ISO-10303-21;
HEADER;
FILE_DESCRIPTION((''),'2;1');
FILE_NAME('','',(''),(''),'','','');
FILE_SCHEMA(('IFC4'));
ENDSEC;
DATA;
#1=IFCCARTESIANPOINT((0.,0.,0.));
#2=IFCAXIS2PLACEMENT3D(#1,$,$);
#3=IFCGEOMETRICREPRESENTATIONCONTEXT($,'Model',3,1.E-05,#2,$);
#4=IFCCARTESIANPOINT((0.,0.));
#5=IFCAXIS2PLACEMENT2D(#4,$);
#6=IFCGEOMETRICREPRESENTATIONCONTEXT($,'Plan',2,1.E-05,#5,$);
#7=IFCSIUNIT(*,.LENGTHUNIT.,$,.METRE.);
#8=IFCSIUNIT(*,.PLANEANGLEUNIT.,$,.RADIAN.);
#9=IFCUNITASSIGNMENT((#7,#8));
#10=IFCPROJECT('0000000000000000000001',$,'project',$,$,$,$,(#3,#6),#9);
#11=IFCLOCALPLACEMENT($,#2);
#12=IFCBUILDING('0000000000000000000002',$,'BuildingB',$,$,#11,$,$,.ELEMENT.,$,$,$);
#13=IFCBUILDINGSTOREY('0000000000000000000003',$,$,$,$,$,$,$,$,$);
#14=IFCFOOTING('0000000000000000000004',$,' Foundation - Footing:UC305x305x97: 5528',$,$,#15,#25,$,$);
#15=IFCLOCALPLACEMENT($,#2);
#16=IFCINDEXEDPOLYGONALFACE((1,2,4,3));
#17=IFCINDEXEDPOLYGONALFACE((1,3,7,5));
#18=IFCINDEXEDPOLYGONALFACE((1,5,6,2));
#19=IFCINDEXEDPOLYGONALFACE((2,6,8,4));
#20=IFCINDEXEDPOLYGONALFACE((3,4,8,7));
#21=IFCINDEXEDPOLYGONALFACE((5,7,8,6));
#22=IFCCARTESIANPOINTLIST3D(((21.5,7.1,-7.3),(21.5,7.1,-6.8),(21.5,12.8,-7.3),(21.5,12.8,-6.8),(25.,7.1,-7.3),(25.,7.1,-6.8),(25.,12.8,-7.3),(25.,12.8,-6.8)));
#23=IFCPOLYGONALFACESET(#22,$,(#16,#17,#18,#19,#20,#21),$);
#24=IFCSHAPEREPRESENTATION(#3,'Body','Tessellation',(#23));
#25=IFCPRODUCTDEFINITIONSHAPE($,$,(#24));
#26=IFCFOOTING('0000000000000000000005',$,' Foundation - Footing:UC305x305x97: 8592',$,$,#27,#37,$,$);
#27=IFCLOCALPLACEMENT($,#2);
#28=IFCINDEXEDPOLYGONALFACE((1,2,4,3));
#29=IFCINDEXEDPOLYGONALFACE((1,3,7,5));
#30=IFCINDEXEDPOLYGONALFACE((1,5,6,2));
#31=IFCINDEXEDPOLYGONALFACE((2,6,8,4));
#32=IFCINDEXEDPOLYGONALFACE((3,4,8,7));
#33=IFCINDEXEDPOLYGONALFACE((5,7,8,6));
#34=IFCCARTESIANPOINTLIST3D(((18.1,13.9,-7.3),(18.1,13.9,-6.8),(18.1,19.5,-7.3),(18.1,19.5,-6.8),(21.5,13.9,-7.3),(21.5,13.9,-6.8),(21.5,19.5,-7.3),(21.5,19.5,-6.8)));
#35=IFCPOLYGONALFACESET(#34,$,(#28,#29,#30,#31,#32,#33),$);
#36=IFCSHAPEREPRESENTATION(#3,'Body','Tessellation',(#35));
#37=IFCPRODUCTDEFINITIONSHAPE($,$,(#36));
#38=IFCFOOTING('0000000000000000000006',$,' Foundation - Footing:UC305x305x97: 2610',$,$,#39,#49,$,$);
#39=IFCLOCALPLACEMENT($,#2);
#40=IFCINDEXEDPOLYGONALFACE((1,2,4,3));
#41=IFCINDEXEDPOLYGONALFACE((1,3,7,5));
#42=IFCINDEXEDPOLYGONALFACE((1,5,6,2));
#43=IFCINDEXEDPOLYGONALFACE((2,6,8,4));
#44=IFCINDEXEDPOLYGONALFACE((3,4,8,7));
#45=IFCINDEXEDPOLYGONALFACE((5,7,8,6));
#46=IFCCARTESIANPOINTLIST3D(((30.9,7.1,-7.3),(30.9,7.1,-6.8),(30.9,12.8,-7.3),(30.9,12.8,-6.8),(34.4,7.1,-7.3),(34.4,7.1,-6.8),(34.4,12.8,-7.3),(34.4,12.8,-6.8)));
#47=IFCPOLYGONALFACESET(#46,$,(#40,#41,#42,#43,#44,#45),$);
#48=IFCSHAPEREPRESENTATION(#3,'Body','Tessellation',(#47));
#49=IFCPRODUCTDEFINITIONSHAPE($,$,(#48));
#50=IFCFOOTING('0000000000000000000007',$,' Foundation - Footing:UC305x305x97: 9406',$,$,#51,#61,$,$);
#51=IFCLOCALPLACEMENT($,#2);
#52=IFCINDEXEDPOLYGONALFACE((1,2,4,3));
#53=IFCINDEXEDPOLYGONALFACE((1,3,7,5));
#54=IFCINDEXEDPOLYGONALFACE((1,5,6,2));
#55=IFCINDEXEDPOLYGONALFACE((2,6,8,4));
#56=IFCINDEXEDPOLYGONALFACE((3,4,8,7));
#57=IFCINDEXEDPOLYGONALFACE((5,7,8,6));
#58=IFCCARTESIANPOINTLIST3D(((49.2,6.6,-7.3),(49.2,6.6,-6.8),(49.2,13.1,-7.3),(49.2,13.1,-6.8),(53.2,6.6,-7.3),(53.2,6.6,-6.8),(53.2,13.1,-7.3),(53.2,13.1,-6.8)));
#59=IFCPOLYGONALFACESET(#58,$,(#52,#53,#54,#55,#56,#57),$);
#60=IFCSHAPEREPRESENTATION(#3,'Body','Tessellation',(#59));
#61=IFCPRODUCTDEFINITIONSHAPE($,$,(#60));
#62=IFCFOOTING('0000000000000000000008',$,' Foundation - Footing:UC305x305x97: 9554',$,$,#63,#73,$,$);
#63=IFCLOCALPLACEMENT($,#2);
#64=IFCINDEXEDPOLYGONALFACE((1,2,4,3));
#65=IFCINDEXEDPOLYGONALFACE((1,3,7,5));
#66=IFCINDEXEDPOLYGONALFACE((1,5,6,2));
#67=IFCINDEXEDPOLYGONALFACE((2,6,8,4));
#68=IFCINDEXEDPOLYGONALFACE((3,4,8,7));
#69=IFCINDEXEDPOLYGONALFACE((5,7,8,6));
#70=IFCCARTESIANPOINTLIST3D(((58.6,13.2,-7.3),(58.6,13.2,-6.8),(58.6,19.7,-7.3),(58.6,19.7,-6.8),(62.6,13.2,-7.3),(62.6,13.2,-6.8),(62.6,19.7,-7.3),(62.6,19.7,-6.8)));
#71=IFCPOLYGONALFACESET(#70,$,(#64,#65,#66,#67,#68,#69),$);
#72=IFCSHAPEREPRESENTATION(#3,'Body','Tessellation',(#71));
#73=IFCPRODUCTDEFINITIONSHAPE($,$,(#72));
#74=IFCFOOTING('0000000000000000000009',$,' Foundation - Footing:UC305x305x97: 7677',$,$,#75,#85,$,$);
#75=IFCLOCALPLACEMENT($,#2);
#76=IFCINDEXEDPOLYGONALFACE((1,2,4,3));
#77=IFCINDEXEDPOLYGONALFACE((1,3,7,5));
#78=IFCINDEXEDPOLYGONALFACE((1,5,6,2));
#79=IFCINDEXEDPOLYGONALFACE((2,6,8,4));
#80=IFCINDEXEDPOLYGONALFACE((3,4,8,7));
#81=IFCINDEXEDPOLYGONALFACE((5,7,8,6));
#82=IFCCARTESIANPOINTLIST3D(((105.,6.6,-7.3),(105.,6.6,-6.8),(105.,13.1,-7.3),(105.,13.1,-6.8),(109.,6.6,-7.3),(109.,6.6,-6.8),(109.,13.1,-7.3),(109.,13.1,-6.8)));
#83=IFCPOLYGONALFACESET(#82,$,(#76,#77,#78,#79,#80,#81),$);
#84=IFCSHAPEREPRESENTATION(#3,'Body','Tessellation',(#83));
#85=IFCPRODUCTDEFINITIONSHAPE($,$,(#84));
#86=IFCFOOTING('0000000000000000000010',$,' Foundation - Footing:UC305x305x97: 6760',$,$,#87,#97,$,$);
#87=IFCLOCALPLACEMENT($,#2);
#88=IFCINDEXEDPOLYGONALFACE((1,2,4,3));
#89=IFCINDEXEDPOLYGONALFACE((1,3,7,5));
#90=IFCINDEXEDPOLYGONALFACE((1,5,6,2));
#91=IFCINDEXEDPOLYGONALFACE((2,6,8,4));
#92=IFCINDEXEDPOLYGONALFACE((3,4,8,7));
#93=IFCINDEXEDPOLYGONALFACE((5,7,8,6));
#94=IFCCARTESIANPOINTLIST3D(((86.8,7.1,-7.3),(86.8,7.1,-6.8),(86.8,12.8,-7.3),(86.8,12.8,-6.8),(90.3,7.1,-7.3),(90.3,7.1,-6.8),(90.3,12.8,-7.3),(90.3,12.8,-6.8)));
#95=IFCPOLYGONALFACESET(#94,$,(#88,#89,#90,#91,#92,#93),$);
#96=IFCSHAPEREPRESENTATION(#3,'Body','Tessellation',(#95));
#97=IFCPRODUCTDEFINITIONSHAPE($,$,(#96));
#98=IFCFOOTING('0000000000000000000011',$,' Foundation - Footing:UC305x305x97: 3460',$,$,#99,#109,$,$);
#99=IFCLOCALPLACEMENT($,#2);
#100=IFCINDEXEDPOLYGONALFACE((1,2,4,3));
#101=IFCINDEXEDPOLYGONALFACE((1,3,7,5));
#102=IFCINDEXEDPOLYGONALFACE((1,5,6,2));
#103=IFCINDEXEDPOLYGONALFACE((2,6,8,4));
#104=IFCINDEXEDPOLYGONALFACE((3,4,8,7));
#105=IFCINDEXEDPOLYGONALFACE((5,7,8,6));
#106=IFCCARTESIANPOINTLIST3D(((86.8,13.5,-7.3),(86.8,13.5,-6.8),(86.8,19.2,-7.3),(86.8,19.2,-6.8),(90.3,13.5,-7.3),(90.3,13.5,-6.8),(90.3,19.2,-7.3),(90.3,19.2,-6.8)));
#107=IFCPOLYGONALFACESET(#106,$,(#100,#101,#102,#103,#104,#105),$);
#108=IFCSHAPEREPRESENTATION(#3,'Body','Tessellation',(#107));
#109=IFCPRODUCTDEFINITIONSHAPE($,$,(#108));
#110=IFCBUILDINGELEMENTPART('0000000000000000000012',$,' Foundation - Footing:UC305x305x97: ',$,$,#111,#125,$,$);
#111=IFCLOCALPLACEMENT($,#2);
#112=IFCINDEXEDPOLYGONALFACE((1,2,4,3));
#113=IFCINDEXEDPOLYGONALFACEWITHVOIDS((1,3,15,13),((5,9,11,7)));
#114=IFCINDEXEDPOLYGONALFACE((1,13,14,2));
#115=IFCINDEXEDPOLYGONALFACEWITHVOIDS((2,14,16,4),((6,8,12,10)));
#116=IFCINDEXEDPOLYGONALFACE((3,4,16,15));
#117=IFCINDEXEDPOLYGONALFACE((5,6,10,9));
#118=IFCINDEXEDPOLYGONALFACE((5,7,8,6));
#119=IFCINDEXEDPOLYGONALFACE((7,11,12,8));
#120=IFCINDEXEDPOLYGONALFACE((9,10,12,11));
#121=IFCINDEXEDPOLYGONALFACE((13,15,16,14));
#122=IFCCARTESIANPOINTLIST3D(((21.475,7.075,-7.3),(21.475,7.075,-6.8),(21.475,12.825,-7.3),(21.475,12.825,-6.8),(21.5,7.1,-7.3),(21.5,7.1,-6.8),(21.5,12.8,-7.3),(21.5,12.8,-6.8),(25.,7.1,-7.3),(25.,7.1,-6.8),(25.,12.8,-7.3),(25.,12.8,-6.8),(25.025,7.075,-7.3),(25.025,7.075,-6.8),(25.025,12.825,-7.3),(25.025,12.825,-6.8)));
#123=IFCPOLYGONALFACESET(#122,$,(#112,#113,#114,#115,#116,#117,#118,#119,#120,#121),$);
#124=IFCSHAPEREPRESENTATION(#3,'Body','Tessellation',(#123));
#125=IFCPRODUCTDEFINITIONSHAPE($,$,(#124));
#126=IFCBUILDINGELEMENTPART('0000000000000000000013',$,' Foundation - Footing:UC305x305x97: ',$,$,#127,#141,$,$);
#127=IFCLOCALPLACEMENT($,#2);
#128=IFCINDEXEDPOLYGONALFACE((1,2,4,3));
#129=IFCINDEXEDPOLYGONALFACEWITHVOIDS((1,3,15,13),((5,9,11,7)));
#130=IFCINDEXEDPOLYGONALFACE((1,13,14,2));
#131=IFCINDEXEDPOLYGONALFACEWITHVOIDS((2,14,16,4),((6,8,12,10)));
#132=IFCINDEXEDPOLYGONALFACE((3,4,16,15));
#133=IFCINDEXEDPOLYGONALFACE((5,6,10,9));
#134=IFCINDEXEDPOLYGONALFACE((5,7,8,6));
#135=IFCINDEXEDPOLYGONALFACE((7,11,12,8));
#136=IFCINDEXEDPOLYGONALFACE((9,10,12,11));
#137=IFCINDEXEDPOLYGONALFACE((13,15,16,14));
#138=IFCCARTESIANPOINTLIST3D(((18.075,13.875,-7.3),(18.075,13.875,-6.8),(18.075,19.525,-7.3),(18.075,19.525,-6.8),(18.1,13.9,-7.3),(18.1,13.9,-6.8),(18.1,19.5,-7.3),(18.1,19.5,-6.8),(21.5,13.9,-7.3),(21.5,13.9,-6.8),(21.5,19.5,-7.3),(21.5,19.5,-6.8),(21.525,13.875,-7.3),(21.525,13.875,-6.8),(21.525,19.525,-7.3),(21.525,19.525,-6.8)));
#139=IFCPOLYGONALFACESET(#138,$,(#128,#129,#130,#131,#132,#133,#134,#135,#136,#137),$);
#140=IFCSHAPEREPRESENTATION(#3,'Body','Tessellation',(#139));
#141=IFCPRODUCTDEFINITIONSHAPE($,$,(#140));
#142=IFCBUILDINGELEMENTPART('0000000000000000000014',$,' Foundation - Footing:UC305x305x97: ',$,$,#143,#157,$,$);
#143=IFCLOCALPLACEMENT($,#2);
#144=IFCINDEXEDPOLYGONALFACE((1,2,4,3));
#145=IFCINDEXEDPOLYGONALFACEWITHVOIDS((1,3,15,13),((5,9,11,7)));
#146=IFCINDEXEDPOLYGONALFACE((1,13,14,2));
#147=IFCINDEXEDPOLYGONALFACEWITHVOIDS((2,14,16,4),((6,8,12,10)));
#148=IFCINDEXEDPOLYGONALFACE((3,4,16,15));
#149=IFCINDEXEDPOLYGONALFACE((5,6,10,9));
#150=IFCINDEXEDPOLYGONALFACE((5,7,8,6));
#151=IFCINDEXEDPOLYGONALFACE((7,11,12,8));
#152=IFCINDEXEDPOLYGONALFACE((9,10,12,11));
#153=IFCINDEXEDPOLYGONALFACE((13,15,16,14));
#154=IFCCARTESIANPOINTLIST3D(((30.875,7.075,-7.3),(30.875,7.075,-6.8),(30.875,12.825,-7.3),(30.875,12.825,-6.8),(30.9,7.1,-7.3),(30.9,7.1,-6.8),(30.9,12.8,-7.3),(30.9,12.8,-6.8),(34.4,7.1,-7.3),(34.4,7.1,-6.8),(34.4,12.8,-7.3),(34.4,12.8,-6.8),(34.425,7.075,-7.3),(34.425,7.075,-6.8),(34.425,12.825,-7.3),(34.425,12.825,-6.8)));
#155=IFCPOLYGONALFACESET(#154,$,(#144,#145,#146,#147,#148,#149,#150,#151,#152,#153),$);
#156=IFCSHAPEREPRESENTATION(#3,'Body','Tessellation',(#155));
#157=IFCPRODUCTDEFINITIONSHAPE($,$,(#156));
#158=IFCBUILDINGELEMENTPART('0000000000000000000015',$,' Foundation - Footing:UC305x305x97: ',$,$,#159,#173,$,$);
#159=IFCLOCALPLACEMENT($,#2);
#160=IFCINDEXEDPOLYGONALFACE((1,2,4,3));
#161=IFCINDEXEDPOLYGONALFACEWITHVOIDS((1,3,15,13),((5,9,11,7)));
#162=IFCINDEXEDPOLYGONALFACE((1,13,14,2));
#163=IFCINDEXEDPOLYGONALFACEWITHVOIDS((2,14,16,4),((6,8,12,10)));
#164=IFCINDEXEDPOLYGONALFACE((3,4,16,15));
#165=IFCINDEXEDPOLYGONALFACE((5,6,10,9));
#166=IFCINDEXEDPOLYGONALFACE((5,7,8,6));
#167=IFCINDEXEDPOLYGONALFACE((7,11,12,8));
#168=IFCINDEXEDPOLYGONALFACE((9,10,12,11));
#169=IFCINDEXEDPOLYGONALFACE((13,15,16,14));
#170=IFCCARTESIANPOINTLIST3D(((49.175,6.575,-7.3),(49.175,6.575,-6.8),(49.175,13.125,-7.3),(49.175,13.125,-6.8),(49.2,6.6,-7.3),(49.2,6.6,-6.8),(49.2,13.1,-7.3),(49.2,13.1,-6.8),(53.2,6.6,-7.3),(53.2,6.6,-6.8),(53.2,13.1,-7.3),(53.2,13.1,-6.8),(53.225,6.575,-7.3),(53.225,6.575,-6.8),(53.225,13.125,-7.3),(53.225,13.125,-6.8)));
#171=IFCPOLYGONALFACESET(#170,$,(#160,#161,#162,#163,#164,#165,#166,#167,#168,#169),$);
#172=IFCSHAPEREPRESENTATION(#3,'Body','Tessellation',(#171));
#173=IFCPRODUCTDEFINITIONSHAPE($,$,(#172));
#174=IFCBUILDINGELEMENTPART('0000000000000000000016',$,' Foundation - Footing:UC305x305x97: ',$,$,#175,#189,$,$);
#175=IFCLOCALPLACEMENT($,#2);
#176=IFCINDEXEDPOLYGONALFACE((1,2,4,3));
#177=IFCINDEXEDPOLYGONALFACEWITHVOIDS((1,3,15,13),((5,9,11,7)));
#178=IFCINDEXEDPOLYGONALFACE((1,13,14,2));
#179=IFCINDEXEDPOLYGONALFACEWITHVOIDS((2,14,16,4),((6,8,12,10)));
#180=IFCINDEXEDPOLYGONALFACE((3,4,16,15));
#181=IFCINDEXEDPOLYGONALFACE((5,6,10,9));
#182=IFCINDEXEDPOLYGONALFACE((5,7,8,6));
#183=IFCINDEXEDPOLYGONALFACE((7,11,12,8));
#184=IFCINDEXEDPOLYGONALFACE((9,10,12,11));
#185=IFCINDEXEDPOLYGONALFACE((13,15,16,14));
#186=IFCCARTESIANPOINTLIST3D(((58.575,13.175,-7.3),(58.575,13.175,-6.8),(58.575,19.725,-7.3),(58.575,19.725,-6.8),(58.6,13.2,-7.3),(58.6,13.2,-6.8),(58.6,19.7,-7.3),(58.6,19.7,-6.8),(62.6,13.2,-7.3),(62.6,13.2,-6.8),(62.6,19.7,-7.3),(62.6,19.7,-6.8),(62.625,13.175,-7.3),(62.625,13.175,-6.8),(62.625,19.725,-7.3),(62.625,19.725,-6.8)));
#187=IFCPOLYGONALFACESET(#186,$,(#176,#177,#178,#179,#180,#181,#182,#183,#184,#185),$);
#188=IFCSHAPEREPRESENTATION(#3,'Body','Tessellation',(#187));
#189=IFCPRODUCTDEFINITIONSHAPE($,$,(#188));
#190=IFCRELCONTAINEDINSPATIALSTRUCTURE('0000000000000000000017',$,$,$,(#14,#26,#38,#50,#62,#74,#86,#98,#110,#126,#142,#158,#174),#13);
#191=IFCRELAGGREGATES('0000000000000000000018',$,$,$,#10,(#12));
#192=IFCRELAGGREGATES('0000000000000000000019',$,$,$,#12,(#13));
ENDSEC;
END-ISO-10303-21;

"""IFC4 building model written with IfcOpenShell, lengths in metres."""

from ifc_helpers import new_model, si_unit, origin, origin_2d, place, context, project, spatial, polyline, outline, extrude, element, save


model = new_model("IFC4")

# Units and contexts
model_context = context("Model", 3, precision=1e-05, world=origin())
plan_context = context("Plan", 2, precision=1e-05, world=origin_2d())
ifc_project = project(units=[si_unit("LENGTHUNIT", "METRE"), si_unit("PLANEANGLEUNIT", "RADIAN")], contexts=[model_context, plan_context])

# Building, storey
building_placement = place(None, origin())
building = spatial("IfcBuilding", under=ifc_project, at=building_placement, Name="BuildingB", CompositionType="ELEMENT")
storey = spatial("IfcBuildingStorey", under=building)

# Footings
element("IfcFooting", 1, inside=storey, Name=" Foundation - Footing:UC305x305x97: 5528", context=model_context, shape_type="SweptSolid", body=[
    extrude(outline(polyline([(25.0, 12.8, -7.3), (21.5, 12.8, -7.3), (21.5, 7.1, -7.3), (25.0, 7.1, -7.3), (25.0, 12.8, -7.3)])), None, (0.0, 0.0, 1.0), 0.5),
])
element("IfcFooting", 2, inside=storey, Name=" Foundation - Footing:UC305x305x97: 8592", context=model_context, shape_type="SweptSolid", body=[
    extrude(outline(polyline([(21.5, 19.5, -7.3), (18.1, 19.5, -7.3), (18.1, 13.9, -7.3), (21.5, 13.9, -7.3), (21.5, 19.5, -7.3)])), None, (0.0, 0.0, 1.0), 0.5),
])
element("IfcFooting", 3, inside=storey, Name=" Foundation - Footing:UC305x305x97: 2610", context=model_context, shape_type="SweptSolid", body=[
    extrude(outline(polyline([(34.4, 12.8, -7.3), (30.9, 12.8, -7.3), (30.9, 7.1, -7.3), (34.4, 7.1, -7.3), (34.4, 12.8, -7.3)])), None, (0.0, 0.0, 1.0), 0.5),
])
element("IfcFooting", 4, inside=storey, Name=" Foundation - Footing:UC305x305x97: 9406", context=model_context, shape_type="SweptSolid", body=[
    extrude(outline(polyline([(53.2, 13.1, -7.3), (49.2, 13.1, -7.3), (49.2, 6.6, -7.3), (53.2, 6.6, -7.3), (53.2, 13.1, -7.3)])), None, (0.0, 0.0, 1.0), 0.5),
])
element("IfcFooting", 5, inside=storey, Name=" Foundation - Footing:UC305x305x97: 9554", context=model_context, shape_type="SweptSolid", body=[
    extrude(outline(polyline([(58.6, 19.7, -7.3), (62.6, 19.7, -7.3), (62.6, 13.2, -7.3), (58.6, 13.2, -7.3), (58.6, 19.7, -7.3)])), None, (0.0, 0.0, 1.0), 0.5),
])
element("IfcFooting", 6, inside=storey, Name=" Foundation - Footing:UC305x305x97: 7677", context=model_context, shape_type="SweptSolid", body=[
    extrude(outline(polyline([(109.0, 13.1, -7.3), (105.0, 13.1, -7.3), (105.0, 6.6, -7.3), (109.0, 6.6, -7.3), (109.0, 13.1, -7.3)])), None, (0.0, 0.0, 1.0), 0.5),
])
element("IfcFooting", 7, inside=storey, Name=" Foundation - Footing:UC305x305x97: 6760", context=model_context, shape_type="SweptSolid", body=[
    extrude(outline(polyline([(86.8, 12.8, -7.3), (90.3, 12.8, -7.3), (90.3, 7.1, -7.3), (86.8, 7.1, -7.3), (86.8, 12.8, -7.3)])), None, (0.0, 0.0, 1.0), 0.5),
])
element("IfcFooting", 8, inside=storey, Name=" Foundation - Footing:UC305x305x97: 3460", context=model_context, shape_type="SweptSolid", body=[
    extrude(outline(polyline([(86.8, 19.2, -7.3), (90.3, 19.2, -7.3), (90.3, 13.5, -7.3), (86.8, 13.5, -7.3), (86.8, 19.2, -7.3)])), None, (0.0, 0.0, 1.0), 0.5),
])

# Building element parts, openings
building_element_part_1 = element("IfcBuildingElementPart", 9, inside=storey, Name=" Foundation - Footing:UC305x305x97: ", context=model_context, shape_type="SweptSolid", body=[
    extrude(outline(polyline([(25.025, 12.825, -7.3), (21.475, 12.825, -7.3), (21.475, 7.075, -7.3), (25.025, 7.075, -7.3), (25.025, 12.825, -7.3)])), None, (0.0, 0.0, 1.0), 0.5),
])
element("IfcOpeningElement", 10, inside=storey, cuts=building_element_part_1, context=model_context, shape_type="SweptSolid", body=[
    extrude(outline(polyline([(25.0, 12.8, -7.3), (21.5, 12.8, -7.3), (21.5, 7.1, -7.3), (25.0, 7.1, -7.3), (25.0, 12.8, -7.3)])), None, (0.0, 0.0, 1.0), 0.5),
])
building_element_part_2 = element("IfcBuildingElementPart", 11, inside=storey, Name=" Foundation - Footing:UC305x305x97: ", context=model_context, shape_type="SweptSolid", body=[
    extrude(outline(polyline([(21.525, 19.525, -7.3), (18.075, 19.525, -7.3), (18.075, 13.875, -7.3), (21.525, 13.875, -7.3), (21.525, 19.525, -7.3)])), None, (0.0, 0.0, 1.0), 0.5),
])
element("IfcOpeningElement", 12, inside=storey, cuts=building_element_part_2, context=model_context, shape_type="SweptSolid", body=[
    extrude(outline(polyline([(21.5, 19.5, -7.3), (18.1, 19.5, -7.3), (18.1, 13.9, -7.3), (21.5, 13.9, -7.3), (21.5, 19.5, -7.3)])), None, (0.0, 0.0, 1.0), 0.5),
])
building_element_part_3 = element("IfcBuildingElementPart", 13, inside=storey, Name=" Foundation - Footing:UC305x305x97: ", context=model_context, shape_type="SweptSolid", body=[
    extrude(outline(polyline([(34.425, 12.825, -7.3), (30.875, 12.825, -7.3), (30.875, 7.075, -7.3), (34.425, 7.075, -7.3), (34.425, 12.825, -7.3)])), None, (0.0, 0.0, 1.0), 0.5),
])
element("IfcOpeningElement", 14, inside=storey, cuts=building_element_part_3, context=model_context, shape_type="SweptSolid", body=[
    extrude(outline(polyline([(34.4, 12.8, -7.3), (30.9, 12.8, -7.3), (30.9, 7.1, -7.3), (34.4, 7.1, -7.3), (34.4, 12.8, -7.3)])), None, (0.0, 0.0, 1.0), 0.5),
])
building_element_part_4 = element("IfcBuildingElementPart", 15, inside=storey, Name=" Foundation - Footing:UC305x305x97: ", context=model_context, shape_type="SweptSolid", body=[
    extrude(outline(polyline([(53.225, 13.125, -7.3), (49.175, 13.125, -7.3), (49.175, 6.575, -7.3), (53.225, 6.575, -7.3), (53.225, 13.125, -7.3)])), None, (0.0, 0.0, 1.0), 0.5),
])
element("IfcOpeningElement", 16, inside=storey, cuts=building_element_part_4, context=model_context, shape_type="SweptSolid", body=[
    extrude(outline(polyline([(53.2, 13.1, -7.3), (49.2, 13.1, -7.3), (49.2, 6.6, -7.3), (53.2, 6.6, -7.3), (53.2, 13.1, -7.3)])), None, (0.0, 0.0, 1.0), 0.5),
])
building_element_part_5 = element("IfcBuildingElementPart", 17, inside=storey, Name=" Foundation - Footing:UC305x305x97: ", context=model_context, shape_type="SweptSolid", body=[
    extrude(outline(polyline([(58.575, 19.725, -7.3), (62.625, 19.725, -7.3), (62.625, 13.175, -7.3), (58.575, 13.175, -7.3), (58.575, 19.725, -7.3)])), None, (0.0, 0.0, 1.0), 0.5),
])
element("IfcOpeningElement", 18, inside=storey, cuts=building_element_part_5, context=model_context, shape_type="SweptSolid", body=[
    extrude(outline(polyline([(58.6, 19.7, -7.3), (62.6, 19.7, -7.3), (62.6, 13.2, -7.3), (58.6, 13.2, -7.3), (58.6, 19.7, -7.3)])), None, (0.0, 0.0, 1.0), 0.5),
])

save(model, "model.ifc")
